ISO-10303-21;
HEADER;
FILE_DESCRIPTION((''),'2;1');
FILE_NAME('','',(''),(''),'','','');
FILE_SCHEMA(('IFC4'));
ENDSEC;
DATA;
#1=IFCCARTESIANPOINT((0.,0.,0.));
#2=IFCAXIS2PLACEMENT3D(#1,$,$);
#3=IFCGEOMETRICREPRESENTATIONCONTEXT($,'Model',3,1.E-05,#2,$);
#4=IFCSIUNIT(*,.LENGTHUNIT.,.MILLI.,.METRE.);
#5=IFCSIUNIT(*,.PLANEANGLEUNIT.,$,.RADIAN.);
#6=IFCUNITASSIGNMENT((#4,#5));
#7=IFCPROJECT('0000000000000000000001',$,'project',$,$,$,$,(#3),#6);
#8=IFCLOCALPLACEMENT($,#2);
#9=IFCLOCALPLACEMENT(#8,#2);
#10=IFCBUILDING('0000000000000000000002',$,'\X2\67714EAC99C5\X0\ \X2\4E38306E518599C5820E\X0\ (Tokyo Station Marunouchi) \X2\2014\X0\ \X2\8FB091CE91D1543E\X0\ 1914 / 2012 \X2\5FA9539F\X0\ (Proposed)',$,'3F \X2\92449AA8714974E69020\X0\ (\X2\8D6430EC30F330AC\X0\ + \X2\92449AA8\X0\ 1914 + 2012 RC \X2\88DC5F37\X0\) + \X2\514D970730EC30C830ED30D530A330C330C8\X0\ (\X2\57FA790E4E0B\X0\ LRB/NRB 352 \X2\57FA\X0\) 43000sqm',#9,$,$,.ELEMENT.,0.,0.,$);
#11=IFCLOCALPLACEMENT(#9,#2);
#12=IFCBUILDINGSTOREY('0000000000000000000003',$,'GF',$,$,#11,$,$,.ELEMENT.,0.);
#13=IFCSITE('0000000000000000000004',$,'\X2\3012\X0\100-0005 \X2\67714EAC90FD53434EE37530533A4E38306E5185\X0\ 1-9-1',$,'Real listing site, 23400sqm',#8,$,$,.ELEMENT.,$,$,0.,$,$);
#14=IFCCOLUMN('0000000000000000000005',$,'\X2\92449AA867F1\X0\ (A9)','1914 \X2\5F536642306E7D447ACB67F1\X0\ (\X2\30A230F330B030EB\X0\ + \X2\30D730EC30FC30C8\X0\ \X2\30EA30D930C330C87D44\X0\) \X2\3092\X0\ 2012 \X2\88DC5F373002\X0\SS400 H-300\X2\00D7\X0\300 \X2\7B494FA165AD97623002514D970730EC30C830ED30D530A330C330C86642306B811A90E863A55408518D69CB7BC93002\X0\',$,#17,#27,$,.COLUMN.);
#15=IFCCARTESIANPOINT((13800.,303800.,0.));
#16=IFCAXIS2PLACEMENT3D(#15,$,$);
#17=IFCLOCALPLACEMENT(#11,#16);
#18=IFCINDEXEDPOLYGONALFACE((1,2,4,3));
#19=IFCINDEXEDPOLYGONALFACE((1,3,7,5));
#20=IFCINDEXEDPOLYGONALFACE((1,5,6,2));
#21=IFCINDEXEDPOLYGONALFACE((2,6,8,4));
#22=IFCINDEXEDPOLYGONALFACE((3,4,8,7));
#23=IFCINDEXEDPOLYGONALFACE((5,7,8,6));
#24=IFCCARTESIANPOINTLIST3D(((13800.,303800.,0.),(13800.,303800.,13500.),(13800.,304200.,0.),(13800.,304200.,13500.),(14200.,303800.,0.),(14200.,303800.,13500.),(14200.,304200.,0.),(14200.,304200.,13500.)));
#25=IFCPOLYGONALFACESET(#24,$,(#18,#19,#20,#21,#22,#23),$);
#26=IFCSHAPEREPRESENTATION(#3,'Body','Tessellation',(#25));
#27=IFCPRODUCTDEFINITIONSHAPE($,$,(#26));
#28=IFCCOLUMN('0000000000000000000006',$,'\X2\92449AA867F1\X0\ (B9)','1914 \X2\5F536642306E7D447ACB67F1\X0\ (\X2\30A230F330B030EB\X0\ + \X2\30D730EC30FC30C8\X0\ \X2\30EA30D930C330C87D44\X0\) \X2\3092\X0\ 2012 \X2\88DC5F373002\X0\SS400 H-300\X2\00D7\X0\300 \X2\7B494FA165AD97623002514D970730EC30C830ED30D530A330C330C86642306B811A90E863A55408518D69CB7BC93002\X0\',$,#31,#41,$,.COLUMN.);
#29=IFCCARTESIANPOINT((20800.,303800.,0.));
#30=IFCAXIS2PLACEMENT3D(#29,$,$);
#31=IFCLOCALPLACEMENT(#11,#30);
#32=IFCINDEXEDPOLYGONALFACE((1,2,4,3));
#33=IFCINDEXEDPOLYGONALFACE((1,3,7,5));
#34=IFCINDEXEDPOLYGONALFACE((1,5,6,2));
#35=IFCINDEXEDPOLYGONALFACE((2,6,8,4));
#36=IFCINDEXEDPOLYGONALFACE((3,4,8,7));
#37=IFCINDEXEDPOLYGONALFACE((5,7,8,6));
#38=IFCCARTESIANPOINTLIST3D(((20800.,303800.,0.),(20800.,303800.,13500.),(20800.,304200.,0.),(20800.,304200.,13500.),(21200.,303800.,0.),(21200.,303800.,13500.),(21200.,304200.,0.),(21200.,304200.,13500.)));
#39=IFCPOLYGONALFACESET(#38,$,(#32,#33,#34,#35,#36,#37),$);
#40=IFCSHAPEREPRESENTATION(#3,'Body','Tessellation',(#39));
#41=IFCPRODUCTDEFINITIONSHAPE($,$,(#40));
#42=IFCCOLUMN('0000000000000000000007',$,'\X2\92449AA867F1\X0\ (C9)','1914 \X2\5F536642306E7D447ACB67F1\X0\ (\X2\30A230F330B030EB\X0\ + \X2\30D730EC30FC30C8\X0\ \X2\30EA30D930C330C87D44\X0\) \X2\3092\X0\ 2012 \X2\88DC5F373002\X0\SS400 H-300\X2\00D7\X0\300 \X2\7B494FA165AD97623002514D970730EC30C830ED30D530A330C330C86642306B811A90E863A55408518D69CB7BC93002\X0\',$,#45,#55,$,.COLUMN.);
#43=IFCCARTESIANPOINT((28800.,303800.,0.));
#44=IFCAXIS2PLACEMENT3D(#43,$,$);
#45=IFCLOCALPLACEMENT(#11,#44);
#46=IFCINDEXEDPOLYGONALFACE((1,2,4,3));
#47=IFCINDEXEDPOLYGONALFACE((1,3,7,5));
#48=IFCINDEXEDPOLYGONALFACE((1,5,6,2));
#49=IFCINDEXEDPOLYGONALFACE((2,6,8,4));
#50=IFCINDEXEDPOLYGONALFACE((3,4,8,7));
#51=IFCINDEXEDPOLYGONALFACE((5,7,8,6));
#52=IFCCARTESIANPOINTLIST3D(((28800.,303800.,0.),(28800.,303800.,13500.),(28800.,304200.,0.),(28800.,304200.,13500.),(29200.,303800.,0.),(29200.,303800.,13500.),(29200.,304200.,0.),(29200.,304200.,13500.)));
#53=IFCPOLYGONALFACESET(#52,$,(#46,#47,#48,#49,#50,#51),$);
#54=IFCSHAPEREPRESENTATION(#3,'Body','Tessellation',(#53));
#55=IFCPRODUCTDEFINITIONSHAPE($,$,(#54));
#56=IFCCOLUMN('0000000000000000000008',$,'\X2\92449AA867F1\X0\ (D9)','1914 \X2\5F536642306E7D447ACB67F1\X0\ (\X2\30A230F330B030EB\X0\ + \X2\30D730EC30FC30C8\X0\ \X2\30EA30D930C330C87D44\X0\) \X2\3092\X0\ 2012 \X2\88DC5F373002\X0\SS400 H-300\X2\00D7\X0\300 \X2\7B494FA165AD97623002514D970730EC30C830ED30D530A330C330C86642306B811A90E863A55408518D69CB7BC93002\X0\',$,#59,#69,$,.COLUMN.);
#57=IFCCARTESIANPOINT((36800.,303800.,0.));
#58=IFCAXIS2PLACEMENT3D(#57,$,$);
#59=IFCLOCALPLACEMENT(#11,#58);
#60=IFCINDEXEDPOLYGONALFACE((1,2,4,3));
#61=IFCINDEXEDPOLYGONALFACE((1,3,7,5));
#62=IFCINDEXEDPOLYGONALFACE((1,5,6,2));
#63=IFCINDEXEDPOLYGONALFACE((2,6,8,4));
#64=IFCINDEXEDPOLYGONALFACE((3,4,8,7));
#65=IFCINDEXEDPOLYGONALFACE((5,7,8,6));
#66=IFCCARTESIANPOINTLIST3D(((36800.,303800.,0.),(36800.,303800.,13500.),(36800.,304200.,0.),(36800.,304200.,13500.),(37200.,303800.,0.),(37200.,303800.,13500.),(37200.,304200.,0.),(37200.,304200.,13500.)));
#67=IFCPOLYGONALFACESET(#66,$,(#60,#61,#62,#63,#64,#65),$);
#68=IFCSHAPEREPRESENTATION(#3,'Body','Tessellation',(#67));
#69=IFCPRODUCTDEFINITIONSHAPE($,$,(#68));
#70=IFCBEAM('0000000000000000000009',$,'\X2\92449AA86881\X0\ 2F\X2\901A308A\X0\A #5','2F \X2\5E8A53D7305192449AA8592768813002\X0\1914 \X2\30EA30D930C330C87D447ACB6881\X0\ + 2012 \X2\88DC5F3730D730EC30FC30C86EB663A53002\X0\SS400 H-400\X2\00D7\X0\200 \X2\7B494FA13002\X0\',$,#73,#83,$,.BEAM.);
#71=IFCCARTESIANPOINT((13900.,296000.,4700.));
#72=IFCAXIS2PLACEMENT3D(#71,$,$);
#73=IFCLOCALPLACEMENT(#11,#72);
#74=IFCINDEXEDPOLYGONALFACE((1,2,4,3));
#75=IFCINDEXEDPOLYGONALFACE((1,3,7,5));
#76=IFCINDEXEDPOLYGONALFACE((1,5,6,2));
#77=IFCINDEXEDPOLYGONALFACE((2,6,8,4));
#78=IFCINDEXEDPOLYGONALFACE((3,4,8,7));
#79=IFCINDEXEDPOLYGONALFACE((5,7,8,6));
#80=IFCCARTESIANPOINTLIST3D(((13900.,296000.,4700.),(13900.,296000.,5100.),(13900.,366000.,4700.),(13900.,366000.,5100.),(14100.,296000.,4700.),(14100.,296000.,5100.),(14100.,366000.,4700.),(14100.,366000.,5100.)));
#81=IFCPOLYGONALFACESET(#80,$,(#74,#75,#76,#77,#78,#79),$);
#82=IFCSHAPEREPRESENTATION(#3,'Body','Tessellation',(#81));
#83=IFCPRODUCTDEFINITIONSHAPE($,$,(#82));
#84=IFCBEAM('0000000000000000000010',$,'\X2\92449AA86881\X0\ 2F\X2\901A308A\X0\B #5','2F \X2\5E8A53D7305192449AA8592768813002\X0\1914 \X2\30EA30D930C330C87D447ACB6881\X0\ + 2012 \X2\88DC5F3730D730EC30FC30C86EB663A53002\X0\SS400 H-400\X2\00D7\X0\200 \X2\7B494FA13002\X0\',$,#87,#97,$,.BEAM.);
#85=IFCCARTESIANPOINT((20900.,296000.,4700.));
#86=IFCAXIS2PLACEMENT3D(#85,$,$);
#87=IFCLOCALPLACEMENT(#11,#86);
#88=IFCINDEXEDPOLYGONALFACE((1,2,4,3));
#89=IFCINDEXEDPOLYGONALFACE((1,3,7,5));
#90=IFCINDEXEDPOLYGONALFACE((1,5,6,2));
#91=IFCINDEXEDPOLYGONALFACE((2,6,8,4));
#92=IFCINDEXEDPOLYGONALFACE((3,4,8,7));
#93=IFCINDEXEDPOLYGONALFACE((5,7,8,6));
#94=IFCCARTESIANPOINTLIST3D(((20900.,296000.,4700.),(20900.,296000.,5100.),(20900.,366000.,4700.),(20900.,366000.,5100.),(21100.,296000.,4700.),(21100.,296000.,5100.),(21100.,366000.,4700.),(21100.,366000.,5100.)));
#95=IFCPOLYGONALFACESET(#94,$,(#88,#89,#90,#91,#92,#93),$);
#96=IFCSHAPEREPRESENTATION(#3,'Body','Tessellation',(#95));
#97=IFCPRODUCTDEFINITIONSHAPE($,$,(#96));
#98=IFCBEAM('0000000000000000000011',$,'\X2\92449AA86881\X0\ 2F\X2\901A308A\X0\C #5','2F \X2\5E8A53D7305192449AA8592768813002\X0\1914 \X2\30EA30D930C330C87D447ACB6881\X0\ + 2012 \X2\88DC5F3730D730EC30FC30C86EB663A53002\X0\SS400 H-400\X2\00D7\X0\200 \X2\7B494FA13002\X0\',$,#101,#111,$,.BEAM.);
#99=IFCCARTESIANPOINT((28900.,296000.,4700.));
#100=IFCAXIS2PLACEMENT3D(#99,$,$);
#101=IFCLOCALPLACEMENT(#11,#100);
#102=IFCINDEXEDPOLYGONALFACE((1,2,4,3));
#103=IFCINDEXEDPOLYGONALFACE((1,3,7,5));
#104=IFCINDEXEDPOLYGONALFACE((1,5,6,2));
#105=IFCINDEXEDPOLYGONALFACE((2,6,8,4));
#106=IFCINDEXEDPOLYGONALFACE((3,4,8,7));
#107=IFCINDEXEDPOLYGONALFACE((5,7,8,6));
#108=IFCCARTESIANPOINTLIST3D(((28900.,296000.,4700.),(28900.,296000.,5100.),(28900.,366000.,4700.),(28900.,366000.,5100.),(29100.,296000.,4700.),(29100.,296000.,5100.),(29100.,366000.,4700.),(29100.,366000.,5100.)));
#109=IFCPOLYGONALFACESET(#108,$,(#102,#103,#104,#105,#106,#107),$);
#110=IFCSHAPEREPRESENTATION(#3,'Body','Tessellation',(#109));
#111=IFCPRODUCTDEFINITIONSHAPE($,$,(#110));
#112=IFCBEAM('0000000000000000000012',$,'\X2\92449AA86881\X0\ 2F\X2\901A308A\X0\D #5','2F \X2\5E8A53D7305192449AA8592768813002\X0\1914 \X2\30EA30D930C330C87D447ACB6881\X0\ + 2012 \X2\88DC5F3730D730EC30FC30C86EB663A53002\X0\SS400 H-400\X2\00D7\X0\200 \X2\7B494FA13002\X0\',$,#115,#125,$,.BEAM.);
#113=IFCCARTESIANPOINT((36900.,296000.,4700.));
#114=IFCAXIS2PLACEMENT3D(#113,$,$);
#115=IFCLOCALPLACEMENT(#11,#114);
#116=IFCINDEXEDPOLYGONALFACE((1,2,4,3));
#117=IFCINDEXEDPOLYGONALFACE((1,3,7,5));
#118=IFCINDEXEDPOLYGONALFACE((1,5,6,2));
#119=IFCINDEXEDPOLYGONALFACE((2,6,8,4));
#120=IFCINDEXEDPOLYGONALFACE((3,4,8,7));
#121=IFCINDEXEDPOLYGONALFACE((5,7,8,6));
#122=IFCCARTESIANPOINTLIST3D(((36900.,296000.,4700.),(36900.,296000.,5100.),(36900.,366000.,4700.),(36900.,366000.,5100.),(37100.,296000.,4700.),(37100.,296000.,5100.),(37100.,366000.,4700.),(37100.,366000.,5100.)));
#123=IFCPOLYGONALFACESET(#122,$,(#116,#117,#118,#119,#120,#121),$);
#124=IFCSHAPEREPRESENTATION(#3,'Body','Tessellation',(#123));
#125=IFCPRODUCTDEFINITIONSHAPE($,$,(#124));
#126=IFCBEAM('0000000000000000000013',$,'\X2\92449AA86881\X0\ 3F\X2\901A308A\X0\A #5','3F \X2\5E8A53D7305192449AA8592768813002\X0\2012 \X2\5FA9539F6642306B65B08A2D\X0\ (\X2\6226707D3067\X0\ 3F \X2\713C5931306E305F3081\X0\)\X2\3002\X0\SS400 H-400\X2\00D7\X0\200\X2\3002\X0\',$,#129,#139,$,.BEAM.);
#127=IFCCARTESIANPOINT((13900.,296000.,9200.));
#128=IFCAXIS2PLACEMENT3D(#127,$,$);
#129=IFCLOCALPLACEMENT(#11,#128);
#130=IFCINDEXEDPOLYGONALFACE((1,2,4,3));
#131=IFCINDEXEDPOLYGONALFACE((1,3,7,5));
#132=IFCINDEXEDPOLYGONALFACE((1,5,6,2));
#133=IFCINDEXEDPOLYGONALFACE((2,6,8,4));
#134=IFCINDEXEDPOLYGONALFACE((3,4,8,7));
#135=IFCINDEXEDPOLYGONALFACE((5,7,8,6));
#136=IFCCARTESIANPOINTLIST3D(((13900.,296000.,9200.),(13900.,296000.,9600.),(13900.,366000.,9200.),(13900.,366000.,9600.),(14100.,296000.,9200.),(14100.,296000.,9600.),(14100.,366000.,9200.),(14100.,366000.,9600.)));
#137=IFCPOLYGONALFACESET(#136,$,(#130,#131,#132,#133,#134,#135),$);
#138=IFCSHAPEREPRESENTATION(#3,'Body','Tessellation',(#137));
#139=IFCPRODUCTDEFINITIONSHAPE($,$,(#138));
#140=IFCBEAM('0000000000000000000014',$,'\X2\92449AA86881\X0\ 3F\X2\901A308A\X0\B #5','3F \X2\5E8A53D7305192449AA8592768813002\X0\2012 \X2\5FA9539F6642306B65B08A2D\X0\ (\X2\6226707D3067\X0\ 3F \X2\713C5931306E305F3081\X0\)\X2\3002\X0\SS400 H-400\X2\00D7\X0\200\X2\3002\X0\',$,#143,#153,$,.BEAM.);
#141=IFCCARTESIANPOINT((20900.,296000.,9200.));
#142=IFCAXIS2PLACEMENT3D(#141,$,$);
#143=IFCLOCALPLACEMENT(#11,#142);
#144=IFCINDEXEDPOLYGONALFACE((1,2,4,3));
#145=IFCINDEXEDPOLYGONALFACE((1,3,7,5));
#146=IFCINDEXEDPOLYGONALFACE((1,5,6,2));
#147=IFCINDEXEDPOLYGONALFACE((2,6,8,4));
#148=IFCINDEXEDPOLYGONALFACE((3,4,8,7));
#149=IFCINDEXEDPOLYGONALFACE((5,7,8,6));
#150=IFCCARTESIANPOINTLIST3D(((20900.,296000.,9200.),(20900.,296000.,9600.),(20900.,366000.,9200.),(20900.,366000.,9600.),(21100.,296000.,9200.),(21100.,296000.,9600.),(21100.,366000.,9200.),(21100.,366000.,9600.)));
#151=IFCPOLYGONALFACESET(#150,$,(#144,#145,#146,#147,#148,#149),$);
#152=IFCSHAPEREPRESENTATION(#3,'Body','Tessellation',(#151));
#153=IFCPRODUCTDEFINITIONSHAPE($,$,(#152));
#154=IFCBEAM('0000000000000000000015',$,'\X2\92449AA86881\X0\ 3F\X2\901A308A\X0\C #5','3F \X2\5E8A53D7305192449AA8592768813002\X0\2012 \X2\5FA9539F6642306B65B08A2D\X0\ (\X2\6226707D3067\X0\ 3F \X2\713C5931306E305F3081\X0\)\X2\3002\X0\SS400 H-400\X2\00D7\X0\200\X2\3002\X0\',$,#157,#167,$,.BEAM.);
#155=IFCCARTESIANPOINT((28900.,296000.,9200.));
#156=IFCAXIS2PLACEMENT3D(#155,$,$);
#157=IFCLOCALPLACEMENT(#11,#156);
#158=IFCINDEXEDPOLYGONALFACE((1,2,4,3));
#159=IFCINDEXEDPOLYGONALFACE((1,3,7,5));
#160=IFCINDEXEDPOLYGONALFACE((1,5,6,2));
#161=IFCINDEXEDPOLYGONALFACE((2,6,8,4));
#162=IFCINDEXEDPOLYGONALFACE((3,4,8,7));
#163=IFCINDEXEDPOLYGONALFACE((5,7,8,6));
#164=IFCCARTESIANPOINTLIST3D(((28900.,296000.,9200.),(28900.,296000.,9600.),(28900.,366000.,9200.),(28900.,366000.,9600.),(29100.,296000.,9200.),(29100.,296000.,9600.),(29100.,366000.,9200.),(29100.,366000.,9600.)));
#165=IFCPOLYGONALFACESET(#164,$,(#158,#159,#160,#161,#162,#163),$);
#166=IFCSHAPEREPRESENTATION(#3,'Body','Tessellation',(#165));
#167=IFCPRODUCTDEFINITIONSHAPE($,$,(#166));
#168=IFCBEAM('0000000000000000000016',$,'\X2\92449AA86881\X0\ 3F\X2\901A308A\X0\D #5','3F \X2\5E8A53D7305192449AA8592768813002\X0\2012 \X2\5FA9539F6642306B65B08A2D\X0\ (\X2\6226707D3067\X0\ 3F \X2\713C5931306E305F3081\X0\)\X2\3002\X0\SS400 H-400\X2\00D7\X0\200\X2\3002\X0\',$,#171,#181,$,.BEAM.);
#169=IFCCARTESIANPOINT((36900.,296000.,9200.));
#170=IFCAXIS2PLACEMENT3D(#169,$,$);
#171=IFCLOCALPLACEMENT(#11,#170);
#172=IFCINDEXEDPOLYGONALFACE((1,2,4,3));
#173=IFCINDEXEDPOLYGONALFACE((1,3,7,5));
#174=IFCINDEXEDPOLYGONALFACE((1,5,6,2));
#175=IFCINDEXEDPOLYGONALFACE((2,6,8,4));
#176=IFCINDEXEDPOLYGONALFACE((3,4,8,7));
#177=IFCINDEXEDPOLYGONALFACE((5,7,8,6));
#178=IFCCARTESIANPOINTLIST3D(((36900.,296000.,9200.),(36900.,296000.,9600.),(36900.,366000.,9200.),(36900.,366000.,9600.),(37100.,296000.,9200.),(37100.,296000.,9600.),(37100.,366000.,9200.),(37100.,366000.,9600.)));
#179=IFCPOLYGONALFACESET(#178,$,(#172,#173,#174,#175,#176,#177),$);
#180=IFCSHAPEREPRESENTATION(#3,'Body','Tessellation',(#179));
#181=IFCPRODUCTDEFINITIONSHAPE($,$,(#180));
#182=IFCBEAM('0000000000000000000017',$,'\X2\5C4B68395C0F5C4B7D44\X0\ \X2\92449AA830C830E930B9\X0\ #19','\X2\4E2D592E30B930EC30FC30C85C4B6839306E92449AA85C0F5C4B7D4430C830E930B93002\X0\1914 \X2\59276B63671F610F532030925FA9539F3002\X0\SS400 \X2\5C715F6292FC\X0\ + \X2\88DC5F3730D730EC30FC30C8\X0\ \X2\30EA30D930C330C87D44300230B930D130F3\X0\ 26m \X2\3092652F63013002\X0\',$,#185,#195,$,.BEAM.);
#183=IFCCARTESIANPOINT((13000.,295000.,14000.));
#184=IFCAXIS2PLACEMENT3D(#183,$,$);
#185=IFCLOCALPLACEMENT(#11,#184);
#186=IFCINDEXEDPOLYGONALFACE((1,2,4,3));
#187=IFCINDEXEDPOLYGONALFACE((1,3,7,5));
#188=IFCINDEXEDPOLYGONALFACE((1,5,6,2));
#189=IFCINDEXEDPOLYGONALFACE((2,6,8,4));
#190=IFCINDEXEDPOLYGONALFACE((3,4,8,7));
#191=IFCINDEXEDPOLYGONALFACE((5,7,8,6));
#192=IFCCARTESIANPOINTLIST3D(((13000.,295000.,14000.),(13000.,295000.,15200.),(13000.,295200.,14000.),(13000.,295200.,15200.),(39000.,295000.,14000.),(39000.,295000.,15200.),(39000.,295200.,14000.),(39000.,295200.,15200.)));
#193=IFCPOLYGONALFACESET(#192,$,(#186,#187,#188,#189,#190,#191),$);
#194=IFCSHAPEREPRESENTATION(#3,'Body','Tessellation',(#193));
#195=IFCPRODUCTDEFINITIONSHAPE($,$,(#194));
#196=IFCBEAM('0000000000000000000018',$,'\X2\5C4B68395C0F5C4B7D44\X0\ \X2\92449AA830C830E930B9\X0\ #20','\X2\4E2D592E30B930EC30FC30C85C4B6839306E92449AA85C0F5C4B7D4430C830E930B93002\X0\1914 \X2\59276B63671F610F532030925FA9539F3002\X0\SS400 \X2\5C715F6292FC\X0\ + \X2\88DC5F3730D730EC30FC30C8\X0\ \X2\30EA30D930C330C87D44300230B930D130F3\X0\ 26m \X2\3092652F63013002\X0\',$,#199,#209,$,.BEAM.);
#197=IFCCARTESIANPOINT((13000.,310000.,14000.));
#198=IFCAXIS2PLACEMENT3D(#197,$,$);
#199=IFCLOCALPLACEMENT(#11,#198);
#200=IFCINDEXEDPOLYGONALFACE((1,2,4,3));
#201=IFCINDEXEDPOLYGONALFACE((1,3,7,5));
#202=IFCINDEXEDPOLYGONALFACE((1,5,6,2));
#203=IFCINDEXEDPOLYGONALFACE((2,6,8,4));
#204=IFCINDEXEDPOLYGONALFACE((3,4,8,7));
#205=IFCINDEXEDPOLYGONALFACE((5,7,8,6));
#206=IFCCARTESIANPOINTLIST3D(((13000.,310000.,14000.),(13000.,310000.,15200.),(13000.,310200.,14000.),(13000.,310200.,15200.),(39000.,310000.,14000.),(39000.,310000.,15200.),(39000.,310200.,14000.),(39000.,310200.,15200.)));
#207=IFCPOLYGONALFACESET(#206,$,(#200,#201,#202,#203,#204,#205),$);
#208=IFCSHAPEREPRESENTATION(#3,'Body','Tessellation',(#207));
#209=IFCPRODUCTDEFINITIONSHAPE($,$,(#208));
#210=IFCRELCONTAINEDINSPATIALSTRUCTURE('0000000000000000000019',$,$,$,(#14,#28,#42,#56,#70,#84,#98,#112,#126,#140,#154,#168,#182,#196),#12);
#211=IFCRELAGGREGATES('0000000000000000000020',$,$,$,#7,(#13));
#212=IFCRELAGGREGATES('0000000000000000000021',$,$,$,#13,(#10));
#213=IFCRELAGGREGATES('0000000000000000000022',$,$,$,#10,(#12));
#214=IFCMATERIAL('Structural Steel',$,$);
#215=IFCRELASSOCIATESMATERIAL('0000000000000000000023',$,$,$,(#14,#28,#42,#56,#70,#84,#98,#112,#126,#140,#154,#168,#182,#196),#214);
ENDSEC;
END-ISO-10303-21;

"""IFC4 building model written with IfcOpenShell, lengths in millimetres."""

from ifc_helpers import new_model, si_unit, frame, frame_2d, origin, place, context, project, spatial, rectangle, extrude, material, element, save


model = new_model("IFC4")

# Units and contexts
model_context = context("Model", 3, precision=1e-05, world=origin())
ifc_project = project(units=[si_unit("LENGTHUNIT", "METRE", prefix="MILLI"), si_unit("PLANEANGLEUNIT", "RADIAN")], contexts=[model_context])

# Site, building, storey
site_placement = place(None, origin())
site = spatial("IfcSite", under=ifc_project, at=site_placement, Name="〒100-0005 東京都千代田区丸の内 1-9-1", ObjectType="Real listing site, 23400sqm", CompositionType="ELEMENT", RefElevation=0.0)
building_placement = place(site_placement, origin())
building = spatial("IfcBuilding", under=site, at=building_placement, Name="東京駅 丸の内駅舎 (Tokyo Station Marunouchi) — 辰野金吾 1914 / 2012 復原 (Proposed)", ObjectType="3F 鉄骨煉瓦造 (赤レンガ + 鉄骨 1914 + 2012 RC 補強) + 免震レトロフィット (基礎下 LRB/NRB 352 基) 43000sqm", CompositionType="ELEMENT", ElevationOfRefHeight=0.0, ElevationOfTerrain=0.0)
storey_placement = place(building_placement, origin())
storey = spatial("IfcBuildingStorey", under=building, at=storey_placement, Name="GF", CompositionType="ELEMENT", Elevation=0.0)

# Columns
ifc_material_1 = material(Name="Structural Steel")
column_1_placement = place(storey_placement, frame((13800.0, 303800.0, 0.0)))
element("IfcColumn", 1, at=column_1_placement, inside=storey, material=ifc_material_1, Name="鉄骨柱 (A9)", Description="1914 当時の組立柱 (アングル + プレート リベット組) を 2012 補強。SS400 H-300×300 等価断面。免震レトロフィット時に脚部接合再構築。", PredefinedType="COLUMN", context=model_context, shape_type="SweptSolid", body=[
    extrude(rectangle(XDim=400.0, YDim=400.0, at=frame_2d((200.0, 200.0))), frame((13800.0, 303800.0, 0.0)), (0.0, 0.0, 1.0), 13500.0),
])
column_2_placement = place(storey_placement, frame((20800.0, 303800.0, 0.0)))
element("IfcColumn", 2, at=column_2_placement, inside=storey, material=ifc_material_1, Name="鉄骨柱 (B9)", Description="1914 当時の組立柱 (アングル + プレート リベット組) を 2012 補強。SS400 H-300×300 等価断面。免震レトロフィット時に脚部接合再構築。", PredefinedType="COLUMN", context=model_context, shape_type="SweptSolid", body=[
    extrude(rectangle(XDim=400.0, YDim=400.0, at=frame_2d((200.0, 200.0))), frame((20800.0, 303800.0, 0.0)), (0.0, 0.0, 1.0), 13500.0),
])
column_3_placement = place(storey_placement, frame((28800.0, 303800.0, 0.0)))
element("IfcColumn", 3, at=column_3_placement, inside=storey, material=ifc_material_1, Name="鉄骨柱 (C9)", Description="1914 当時の組立柱 (アングル + プレート リベット組) を 2012 補強。SS400 H-300×300 等価断面。免震レトロフィット時に脚部接合再構築。", PredefinedType="COLUMN", context=model_context, shape_type="SweptSolid", body=[
    extrude(rectangle(XDim=400.0, YDim=400.0, at=frame_2d((200.0, 200.0))), frame((28800.0, 303800.0, 0.0)), (0.0, 0.0, 1.0), 13500.0),
])
column_4_placement = place(storey_placement, frame((36800.0, 303800.0, 0.0)))
element("IfcColumn", 4, at=column_4_placement, inside=storey, material=ifc_material_1, Name="鉄骨柱 (D9)", Description="1914 当時の組立柱 (アングル + プレート リベット組) を 2012 補強。SS400 H-300×300 等価断面。免震レトロフィット時に脚部接合再構築。", PredefinedType="COLUMN", context=model_context, shape_type="SweptSolid", body=[
    extrude(rectangle(XDim=400.0, YDim=400.0, at=frame_2d((200.0, 200.0))), frame((36800.0, 303800.0, 0.0)), (0.0, 0.0, 1.0), 13500.0),
])

# Beams
beam_1_placement = place(storey_placement, frame((13900.0, 296000.0, 4700.0)))
element("IfcBeam", 5, at=beam_1_placement, inside=storey, material=ifc_material_1, Name="鉄骨梁 2F通りA #5", Description="2F 床受け鉄骨大梁。1914 リベット組立梁 + 2012 補強プレート溶接。SS400 H-400×200 等価。", PredefinedType="BEAM", context=model_context, shape_type="SweptSolid", body=[
    extrude(rectangle(XDim=200.0, YDim=70000.0, at=frame_2d((100.0, 35000.0))), frame((13900.0, 296000.0, 4700.0)), (0.0, 0.0, 1.0), 400.0),
])
beam_2_placement = place(storey_placement, frame((20900.0, 296000.0, 4700.0)))
element("IfcBeam", 6, at=beam_2_placement, inside=storey, material=ifc_material_1, Name="鉄骨梁 2F通りB #5", Description="2F 床受け鉄骨大梁。1914 リベット組立梁 + 2012 補強プレート溶接。SS400 H-400×200 等価。", PredefinedType="BEAM", context=model_context, shape_type="SweptSolid", body=[
    extrude(rectangle(XDim=200.0, YDim=70000.0, at=frame_2d((100.0, 35000.0))), frame((20900.0, 296000.0, 4700.0)), (0.0, 0.0, 1.0), 400.0),
])
beam_3_placement = place(storey_placement, frame((28900.0, 296000.0, 4700.0)))
element("IfcBeam", 7, at=beam_3_placement, inside=storey, material=ifc_material_1, Name="鉄骨梁 2F通りC #5", Description="2F 床受け鉄骨大梁。1914 リベット組立梁 + 2012 補強プレート溶接。SS400 H-400×200 等価。", PredefinedType="BEAM", context=model_context, shape_type="SweptSolid", body=[
    extrude(rectangle(XDim=200.0, YDim=70000.0, at=frame_2d((100.0, 35000.0))), frame((28900.0, 296000.0, 4700.0)), (0.0, 0.0, 1.0), 400.0),
])
beam_4_placement = place(storey_placement, frame((36900.0, 296000.0, 4700.0)))
element("IfcBeam", 8, at=beam_4_placement, inside=storey, material=ifc_material_1, Name="鉄骨梁 2F通りD #5", Description="2F 床受け鉄骨大梁。1914 リベット組立梁 + 2012 補強プレート溶接。SS400 H-400×200 等価。", PredefinedType="BEAM", context=model_context, shape_type="SweptSolid", body=[
    extrude(rectangle(XDim=200.0, YDim=70000.0, at=frame_2d((100.0, 35000.0))), frame((36900.0, 296000.0, 4700.0)), (0.0, 0.0, 1.0), 400.0),
])
beam_5_placement = place(storey_placement, frame((13900.0, 296000.0, 9200.0)))
element("IfcBeam", 9, at=beam_5_placement, inside=storey, material=ifc_material_1, Name="鉄骨梁 3F通りA #5", Description="3F 床受け鉄骨大梁。2012 復原時に新設 (戦災で 3F 焼失のため)。SS400 H-400×200。", PredefinedType="BEAM", context=model_context, shape_type="SweptSolid", body=[
    extrude(rectangle(XDim=200.0, YDim=70000.0, at=frame_2d((100.0, 35000.0))), frame((13900.0, 296000.0, 9200.0)), (0.0, 0.0, 1.0), 400.0),
])
beam_6_placement = place(storey_placement, frame((20900.0, 296000.0, 9200.0)))
element("IfcBeam", 10, at=beam_6_placement, inside=storey, material=ifc_material_1, Name="鉄骨梁 3F通りB #5", Description="3F 床受け鉄骨大梁。2012 復原時に新設 (戦災で 3F 焼失のため)。SS400 H-400×200。", PredefinedType="BEAM", context=model_context, shape_type="SweptSolid", body=[
    extrude(rectangle(XDim=200.0, YDim=70000.0, at=frame_2d((100.0, 35000.0))), frame((20900.0, 296000.0, 9200.0)), (0.0, 0.0, 1.0), 400.0),
])
beam_7_placement = place(storey_placement, frame((28900.0, 296000.0, 9200.0)))
element("IfcBeam", 11, at=beam_7_placement, inside=storey, material=ifc_material_1, Name="鉄骨梁 3F通りC #5", Description="3F 床受け鉄骨大梁。2012 復原時に新設 (戦災で 3F 焼失のため)。SS400 H-400×200。", PredefinedType="BEAM", context=model_context, shape_type="SweptSolid", body=[
    extrude(rectangle(XDim=200.0, YDim=70000.0, at=frame_2d((100.0, 35000.0))), frame((28900.0, 296000.0, 9200.0)), (0.0, 0.0, 1.0), 400.0),
])
beam_8_placement = place(storey_placement, frame((36900.0, 296000.0, 9200.0)))
element("IfcBeam", 12, at=beam_8_placement, inside=storey, material=ifc_material_1, Name="鉄骨梁 3F通りD #5", Description="3F 床受け鉄骨大梁。2012 復原時に新設 (戦災で 3F 焼失のため)。SS400 H-400×200。", PredefinedType="BEAM", context=model_context, shape_type="SweptSolid", body=[
    extrude(rectangle(XDim=200.0, YDim=70000.0, at=frame_2d((100.0, 35000.0))), frame((36900.0, 296000.0, 9200.0)), (0.0, 0.0, 1.0), 400.0),
])
beam_9_placement = place(storey_placement, frame((13000.0, 295000.0, 14000.0)))
element("IfcBeam", 13, at=beam_9_placement, inside=storey, material=ifc_material_1, Name="屋根小屋組 鉄骨トラス #19", Description="中央スレート屋根の鉄骨小屋組トラス。1914 大正期意匠を復原。SS400 山形鋼 + 補強プレート リベット組。スパン 26m を支持。", PredefinedType="BEAM", context=model_context, shape_type="SweptSolid", body=[
    extrude(rectangle(XDim=26000.0, YDim=200.0, at=frame_2d((13000.0, 100.0))), frame((13000.0, 295000.0, 14000.0)), (0.0, 0.0, 1.0), 1200.0),
])
beam_10_placement = place(storey_placement, frame((13000.0, 310000.0, 14000.0)))
element("IfcBeam", 14, at=beam_10_placement, inside=storey, material=ifc_material_1, Name="屋根小屋組 鉄骨トラス #20", Description="中央スレート屋根の鉄骨小屋組トラス。1914 大正期意匠を復原。SS400 山形鋼 + 補強プレート リベット組。スパン 26m を支持。", PredefinedType="BEAM", context=model_context, shape_type="SweptSolid", body=[
    extrude(rectangle(XDim=26000.0, YDim=200.0, at=frame_2d((13000.0, 100.0))), frame((13000.0, 310000.0, 14000.0)), (0.0, 0.0, 1.0), 1200.0),
])

save(model, "model.ifc")
